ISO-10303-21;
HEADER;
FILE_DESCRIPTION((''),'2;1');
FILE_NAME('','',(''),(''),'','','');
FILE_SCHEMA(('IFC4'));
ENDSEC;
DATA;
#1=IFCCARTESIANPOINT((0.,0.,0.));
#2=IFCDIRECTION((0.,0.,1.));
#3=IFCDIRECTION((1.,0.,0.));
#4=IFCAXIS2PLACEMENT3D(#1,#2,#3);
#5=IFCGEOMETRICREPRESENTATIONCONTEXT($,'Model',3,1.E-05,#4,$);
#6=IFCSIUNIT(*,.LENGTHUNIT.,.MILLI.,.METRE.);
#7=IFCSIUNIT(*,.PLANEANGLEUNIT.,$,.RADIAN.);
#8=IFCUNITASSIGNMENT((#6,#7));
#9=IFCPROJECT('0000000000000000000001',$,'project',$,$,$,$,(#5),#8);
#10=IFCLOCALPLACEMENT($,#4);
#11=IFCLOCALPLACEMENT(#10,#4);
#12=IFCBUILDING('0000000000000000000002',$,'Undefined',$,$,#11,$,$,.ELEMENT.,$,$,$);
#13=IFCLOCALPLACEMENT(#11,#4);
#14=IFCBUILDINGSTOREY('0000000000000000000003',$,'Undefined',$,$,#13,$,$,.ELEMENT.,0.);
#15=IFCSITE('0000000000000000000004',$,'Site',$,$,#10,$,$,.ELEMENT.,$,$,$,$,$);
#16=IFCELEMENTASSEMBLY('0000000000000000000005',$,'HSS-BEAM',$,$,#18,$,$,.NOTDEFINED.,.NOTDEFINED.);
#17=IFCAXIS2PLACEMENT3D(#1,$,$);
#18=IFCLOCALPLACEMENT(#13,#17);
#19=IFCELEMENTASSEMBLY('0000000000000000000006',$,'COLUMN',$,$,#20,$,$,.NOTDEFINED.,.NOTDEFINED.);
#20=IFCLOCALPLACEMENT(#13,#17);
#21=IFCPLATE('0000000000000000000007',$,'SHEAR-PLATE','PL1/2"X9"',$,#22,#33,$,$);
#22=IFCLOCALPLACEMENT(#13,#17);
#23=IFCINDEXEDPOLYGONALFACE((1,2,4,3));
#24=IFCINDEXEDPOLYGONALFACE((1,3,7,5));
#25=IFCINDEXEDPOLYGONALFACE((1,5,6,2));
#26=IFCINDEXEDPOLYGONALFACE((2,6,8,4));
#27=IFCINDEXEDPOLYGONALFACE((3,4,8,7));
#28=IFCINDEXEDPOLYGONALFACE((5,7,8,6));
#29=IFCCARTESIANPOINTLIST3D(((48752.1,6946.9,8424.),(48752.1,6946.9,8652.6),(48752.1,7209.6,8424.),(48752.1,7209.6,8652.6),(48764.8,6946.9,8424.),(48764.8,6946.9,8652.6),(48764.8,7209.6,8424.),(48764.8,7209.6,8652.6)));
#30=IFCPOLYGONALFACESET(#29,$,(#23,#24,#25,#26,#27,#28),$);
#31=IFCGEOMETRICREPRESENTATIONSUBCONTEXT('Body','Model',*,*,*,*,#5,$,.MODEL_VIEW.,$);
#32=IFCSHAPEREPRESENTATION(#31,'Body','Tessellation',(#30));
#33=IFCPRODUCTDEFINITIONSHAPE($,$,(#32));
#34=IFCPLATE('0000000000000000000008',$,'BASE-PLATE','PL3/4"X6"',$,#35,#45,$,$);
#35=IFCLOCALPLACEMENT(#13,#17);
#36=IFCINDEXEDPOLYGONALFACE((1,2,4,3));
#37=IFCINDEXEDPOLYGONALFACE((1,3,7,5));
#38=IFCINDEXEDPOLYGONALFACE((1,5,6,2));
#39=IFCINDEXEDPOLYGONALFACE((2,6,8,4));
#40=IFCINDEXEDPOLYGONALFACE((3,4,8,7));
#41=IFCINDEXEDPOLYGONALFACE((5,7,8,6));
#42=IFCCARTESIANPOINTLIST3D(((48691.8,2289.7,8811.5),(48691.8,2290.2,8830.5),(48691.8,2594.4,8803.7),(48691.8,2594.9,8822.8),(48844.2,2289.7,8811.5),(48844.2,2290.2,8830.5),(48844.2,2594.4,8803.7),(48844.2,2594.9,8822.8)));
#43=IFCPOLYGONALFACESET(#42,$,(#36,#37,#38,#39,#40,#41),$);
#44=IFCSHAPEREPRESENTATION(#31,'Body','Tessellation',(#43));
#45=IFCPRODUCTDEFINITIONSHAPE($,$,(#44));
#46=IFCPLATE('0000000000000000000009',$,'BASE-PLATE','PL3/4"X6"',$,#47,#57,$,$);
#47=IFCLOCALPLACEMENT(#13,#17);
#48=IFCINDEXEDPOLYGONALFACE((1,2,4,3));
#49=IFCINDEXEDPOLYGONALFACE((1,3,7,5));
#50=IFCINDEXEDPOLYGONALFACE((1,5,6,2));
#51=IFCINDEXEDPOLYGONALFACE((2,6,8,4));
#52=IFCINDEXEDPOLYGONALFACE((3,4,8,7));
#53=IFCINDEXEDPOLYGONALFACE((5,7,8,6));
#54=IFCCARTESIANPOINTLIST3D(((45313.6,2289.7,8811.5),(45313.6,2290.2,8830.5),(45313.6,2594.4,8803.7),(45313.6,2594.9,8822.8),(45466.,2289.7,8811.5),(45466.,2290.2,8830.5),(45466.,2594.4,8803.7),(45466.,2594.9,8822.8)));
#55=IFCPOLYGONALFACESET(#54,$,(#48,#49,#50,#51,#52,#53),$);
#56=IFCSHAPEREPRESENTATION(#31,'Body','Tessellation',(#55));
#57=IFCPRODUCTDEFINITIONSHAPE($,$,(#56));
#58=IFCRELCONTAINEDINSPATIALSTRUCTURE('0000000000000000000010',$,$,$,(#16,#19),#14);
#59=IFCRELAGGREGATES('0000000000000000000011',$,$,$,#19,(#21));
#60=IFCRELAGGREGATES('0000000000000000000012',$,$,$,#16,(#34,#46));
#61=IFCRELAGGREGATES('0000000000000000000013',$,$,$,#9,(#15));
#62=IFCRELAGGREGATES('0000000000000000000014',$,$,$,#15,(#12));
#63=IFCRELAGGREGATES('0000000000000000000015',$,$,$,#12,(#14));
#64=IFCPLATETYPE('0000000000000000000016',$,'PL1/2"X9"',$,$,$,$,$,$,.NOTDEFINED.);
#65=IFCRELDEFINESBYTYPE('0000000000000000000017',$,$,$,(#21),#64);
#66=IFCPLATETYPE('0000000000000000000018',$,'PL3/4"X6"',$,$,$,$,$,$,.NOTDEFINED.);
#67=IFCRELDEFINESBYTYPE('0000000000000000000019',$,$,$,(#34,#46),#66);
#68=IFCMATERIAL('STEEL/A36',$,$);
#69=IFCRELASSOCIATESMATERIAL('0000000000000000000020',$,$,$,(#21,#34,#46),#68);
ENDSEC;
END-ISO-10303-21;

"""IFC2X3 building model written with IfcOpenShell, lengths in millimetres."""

from ifc_helpers import new_model, si_unit, frame, origin_with_axes, place, context, subcontext, project, spatial, polyline, outline, extrude, material, type_object, element, aggregate, save


model = new_model("IFC2X3")

# Units and contexts
model_context = context("Model", 3, precision=1e-05, world=origin_with_axes())
body_context = subcontext(model_context, "Body", "Model", "MODEL_VIEW")
ifc_project = project(units=[si_unit("LENGTHUNIT", "METRE", prefix="MILLI"), si_unit("PLANEANGLEUNIT", "RADIAN")], contexts=[model_context])

# Site, building, storey
site_placement = place(None, origin_with_axes())
site = spatial("IfcSite", under=ifc_project, at=site_placement, Name="Site", CompositionType="ELEMENT")
building_placement = place(site_placement, origin_with_axes())
building = spatial("IfcBuilding", under=site, at=building_placement, Name="Undefined", CompositionType="ELEMENT")
storey_placement = place(building_placement, origin_with_axes())
storey = spatial("IfcBuildingStorey", under=building, at=storey_placement, Name="Undefined", CompositionType="ELEMENT", Elevation=0.0)

# Shared definitions
ifc_material_1 = material(Name="STEEL/A36")

# Element assembly
assembly_1_placement = place(storey_placement, origin_with_axes())
assembly_1 = element("IfcElementAssembly", 1, at=assembly_1_placement, inside=storey, Name="HSS-BEAM", AssemblyPlace="NOTDEFINED", PredefinedType="NOTDEFINED")

# Element assembly
assembly_2_placement = place(storey_placement, origin_with_axes())
assembly_2 = element("IfcElementAssembly", 2, at=assembly_2_placement, inside=storey, Name="COLUMN", AssemblyPlace="NOTDEFINED", PredefinedType="NOTDEFINED")

# Plates
plate_type_1 = type_object("IfcPlateType", Name="PL1/2\"X9\"", PredefinedType="NOTDEFINED")
plate_1_placement = place(assembly_2_placement, frame((48758.5, 7209.6, 8652.6), z_axis=(-1.0, 0.0, 0.0), x_axis=(0.0, 0.0, -1.0)))
plate_1 = element("IfcPlate", 3, at=plate_1_placement, type_object=plate_type_1, material=ifc_material_1, Name="SHEAR-PLATE", Description="PL1/2\"X9\"", context=body_context, shape_type="SweptSolid", body=[
    extrude(outline(polyline([(0.0, 0.0), (228.6, 0.0), (228.6, 262.7), (0.0, 262.7), (0.0, 0.0)])), frame((0.0, 0.0, -6.3), z_axis=(0.0, 0.0, 1.0), x_axis=(1.0, 0.0, 0.0)), (0.0, 0.0, 1.0), 12.7),
])
aggregate(assembly_2, [plate_1])
plate_type_2 = type_object("IfcPlateType", Name="PL3/4\"X6\"", PredefinedType="NOTDEFINED")
plate_2_placement = place(assembly_1_placement, frame((48844.2, 2594.7, 8813.3), z_axis=(0.0, 0.025308, 0.99968), x_axis=(-1.0, 0.0, 0.0)))
plate_2 = element("IfcPlate", 4, at=plate_2_placement, type_object=plate_type_2, material=ifc_material_1, Name="BASE-PLATE", Description="PL3/4\"X6\"", context=body_context, shape_type="SweptSolid", body=[
    extrude(outline(polyline([(0.0, 0.0), (152.4, 0.0), (152.4, 304.8), (0.0, 304.8), (0.0, 0.0)])), frame((0.0, 0.0, -9.5), z_axis=(0.0, 0.0, 1.0), x_axis=(1.0, 0.0, 0.0)), (0.0, 0.0, 1.0), 19.1),
])
plate_3_placement = place(assembly_1_placement, frame((45466.0, 2594.7, 8813.3), z_axis=(0.0, 0.025308, 0.99968), x_axis=(-1.0, 0.0, 0.0)))
plate_3 = element("IfcPlate", 5, at=plate_3_placement, type_object=plate_type_2, material=ifc_material_1, Name="BASE-PLATE", Description="PL3/4\"X6\"", context=body_context, shape_type="SweptSolid", body=[
    extrude(outline(polyline([(0.0, 0.0), (152.4, 0.0), (152.4, 304.8), (0.0, 304.8), (0.0, 0.0)])), frame((0.0, 0.0, -9.5), z_axis=(0.0, 0.0, 1.0), x_axis=(1.0, 0.0, 0.0)), (0.0, 0.0, 1.0), 19.1),
])
aggregate(assembly_1, [plate_2, plate_3])

save(model, "model.ifc")
